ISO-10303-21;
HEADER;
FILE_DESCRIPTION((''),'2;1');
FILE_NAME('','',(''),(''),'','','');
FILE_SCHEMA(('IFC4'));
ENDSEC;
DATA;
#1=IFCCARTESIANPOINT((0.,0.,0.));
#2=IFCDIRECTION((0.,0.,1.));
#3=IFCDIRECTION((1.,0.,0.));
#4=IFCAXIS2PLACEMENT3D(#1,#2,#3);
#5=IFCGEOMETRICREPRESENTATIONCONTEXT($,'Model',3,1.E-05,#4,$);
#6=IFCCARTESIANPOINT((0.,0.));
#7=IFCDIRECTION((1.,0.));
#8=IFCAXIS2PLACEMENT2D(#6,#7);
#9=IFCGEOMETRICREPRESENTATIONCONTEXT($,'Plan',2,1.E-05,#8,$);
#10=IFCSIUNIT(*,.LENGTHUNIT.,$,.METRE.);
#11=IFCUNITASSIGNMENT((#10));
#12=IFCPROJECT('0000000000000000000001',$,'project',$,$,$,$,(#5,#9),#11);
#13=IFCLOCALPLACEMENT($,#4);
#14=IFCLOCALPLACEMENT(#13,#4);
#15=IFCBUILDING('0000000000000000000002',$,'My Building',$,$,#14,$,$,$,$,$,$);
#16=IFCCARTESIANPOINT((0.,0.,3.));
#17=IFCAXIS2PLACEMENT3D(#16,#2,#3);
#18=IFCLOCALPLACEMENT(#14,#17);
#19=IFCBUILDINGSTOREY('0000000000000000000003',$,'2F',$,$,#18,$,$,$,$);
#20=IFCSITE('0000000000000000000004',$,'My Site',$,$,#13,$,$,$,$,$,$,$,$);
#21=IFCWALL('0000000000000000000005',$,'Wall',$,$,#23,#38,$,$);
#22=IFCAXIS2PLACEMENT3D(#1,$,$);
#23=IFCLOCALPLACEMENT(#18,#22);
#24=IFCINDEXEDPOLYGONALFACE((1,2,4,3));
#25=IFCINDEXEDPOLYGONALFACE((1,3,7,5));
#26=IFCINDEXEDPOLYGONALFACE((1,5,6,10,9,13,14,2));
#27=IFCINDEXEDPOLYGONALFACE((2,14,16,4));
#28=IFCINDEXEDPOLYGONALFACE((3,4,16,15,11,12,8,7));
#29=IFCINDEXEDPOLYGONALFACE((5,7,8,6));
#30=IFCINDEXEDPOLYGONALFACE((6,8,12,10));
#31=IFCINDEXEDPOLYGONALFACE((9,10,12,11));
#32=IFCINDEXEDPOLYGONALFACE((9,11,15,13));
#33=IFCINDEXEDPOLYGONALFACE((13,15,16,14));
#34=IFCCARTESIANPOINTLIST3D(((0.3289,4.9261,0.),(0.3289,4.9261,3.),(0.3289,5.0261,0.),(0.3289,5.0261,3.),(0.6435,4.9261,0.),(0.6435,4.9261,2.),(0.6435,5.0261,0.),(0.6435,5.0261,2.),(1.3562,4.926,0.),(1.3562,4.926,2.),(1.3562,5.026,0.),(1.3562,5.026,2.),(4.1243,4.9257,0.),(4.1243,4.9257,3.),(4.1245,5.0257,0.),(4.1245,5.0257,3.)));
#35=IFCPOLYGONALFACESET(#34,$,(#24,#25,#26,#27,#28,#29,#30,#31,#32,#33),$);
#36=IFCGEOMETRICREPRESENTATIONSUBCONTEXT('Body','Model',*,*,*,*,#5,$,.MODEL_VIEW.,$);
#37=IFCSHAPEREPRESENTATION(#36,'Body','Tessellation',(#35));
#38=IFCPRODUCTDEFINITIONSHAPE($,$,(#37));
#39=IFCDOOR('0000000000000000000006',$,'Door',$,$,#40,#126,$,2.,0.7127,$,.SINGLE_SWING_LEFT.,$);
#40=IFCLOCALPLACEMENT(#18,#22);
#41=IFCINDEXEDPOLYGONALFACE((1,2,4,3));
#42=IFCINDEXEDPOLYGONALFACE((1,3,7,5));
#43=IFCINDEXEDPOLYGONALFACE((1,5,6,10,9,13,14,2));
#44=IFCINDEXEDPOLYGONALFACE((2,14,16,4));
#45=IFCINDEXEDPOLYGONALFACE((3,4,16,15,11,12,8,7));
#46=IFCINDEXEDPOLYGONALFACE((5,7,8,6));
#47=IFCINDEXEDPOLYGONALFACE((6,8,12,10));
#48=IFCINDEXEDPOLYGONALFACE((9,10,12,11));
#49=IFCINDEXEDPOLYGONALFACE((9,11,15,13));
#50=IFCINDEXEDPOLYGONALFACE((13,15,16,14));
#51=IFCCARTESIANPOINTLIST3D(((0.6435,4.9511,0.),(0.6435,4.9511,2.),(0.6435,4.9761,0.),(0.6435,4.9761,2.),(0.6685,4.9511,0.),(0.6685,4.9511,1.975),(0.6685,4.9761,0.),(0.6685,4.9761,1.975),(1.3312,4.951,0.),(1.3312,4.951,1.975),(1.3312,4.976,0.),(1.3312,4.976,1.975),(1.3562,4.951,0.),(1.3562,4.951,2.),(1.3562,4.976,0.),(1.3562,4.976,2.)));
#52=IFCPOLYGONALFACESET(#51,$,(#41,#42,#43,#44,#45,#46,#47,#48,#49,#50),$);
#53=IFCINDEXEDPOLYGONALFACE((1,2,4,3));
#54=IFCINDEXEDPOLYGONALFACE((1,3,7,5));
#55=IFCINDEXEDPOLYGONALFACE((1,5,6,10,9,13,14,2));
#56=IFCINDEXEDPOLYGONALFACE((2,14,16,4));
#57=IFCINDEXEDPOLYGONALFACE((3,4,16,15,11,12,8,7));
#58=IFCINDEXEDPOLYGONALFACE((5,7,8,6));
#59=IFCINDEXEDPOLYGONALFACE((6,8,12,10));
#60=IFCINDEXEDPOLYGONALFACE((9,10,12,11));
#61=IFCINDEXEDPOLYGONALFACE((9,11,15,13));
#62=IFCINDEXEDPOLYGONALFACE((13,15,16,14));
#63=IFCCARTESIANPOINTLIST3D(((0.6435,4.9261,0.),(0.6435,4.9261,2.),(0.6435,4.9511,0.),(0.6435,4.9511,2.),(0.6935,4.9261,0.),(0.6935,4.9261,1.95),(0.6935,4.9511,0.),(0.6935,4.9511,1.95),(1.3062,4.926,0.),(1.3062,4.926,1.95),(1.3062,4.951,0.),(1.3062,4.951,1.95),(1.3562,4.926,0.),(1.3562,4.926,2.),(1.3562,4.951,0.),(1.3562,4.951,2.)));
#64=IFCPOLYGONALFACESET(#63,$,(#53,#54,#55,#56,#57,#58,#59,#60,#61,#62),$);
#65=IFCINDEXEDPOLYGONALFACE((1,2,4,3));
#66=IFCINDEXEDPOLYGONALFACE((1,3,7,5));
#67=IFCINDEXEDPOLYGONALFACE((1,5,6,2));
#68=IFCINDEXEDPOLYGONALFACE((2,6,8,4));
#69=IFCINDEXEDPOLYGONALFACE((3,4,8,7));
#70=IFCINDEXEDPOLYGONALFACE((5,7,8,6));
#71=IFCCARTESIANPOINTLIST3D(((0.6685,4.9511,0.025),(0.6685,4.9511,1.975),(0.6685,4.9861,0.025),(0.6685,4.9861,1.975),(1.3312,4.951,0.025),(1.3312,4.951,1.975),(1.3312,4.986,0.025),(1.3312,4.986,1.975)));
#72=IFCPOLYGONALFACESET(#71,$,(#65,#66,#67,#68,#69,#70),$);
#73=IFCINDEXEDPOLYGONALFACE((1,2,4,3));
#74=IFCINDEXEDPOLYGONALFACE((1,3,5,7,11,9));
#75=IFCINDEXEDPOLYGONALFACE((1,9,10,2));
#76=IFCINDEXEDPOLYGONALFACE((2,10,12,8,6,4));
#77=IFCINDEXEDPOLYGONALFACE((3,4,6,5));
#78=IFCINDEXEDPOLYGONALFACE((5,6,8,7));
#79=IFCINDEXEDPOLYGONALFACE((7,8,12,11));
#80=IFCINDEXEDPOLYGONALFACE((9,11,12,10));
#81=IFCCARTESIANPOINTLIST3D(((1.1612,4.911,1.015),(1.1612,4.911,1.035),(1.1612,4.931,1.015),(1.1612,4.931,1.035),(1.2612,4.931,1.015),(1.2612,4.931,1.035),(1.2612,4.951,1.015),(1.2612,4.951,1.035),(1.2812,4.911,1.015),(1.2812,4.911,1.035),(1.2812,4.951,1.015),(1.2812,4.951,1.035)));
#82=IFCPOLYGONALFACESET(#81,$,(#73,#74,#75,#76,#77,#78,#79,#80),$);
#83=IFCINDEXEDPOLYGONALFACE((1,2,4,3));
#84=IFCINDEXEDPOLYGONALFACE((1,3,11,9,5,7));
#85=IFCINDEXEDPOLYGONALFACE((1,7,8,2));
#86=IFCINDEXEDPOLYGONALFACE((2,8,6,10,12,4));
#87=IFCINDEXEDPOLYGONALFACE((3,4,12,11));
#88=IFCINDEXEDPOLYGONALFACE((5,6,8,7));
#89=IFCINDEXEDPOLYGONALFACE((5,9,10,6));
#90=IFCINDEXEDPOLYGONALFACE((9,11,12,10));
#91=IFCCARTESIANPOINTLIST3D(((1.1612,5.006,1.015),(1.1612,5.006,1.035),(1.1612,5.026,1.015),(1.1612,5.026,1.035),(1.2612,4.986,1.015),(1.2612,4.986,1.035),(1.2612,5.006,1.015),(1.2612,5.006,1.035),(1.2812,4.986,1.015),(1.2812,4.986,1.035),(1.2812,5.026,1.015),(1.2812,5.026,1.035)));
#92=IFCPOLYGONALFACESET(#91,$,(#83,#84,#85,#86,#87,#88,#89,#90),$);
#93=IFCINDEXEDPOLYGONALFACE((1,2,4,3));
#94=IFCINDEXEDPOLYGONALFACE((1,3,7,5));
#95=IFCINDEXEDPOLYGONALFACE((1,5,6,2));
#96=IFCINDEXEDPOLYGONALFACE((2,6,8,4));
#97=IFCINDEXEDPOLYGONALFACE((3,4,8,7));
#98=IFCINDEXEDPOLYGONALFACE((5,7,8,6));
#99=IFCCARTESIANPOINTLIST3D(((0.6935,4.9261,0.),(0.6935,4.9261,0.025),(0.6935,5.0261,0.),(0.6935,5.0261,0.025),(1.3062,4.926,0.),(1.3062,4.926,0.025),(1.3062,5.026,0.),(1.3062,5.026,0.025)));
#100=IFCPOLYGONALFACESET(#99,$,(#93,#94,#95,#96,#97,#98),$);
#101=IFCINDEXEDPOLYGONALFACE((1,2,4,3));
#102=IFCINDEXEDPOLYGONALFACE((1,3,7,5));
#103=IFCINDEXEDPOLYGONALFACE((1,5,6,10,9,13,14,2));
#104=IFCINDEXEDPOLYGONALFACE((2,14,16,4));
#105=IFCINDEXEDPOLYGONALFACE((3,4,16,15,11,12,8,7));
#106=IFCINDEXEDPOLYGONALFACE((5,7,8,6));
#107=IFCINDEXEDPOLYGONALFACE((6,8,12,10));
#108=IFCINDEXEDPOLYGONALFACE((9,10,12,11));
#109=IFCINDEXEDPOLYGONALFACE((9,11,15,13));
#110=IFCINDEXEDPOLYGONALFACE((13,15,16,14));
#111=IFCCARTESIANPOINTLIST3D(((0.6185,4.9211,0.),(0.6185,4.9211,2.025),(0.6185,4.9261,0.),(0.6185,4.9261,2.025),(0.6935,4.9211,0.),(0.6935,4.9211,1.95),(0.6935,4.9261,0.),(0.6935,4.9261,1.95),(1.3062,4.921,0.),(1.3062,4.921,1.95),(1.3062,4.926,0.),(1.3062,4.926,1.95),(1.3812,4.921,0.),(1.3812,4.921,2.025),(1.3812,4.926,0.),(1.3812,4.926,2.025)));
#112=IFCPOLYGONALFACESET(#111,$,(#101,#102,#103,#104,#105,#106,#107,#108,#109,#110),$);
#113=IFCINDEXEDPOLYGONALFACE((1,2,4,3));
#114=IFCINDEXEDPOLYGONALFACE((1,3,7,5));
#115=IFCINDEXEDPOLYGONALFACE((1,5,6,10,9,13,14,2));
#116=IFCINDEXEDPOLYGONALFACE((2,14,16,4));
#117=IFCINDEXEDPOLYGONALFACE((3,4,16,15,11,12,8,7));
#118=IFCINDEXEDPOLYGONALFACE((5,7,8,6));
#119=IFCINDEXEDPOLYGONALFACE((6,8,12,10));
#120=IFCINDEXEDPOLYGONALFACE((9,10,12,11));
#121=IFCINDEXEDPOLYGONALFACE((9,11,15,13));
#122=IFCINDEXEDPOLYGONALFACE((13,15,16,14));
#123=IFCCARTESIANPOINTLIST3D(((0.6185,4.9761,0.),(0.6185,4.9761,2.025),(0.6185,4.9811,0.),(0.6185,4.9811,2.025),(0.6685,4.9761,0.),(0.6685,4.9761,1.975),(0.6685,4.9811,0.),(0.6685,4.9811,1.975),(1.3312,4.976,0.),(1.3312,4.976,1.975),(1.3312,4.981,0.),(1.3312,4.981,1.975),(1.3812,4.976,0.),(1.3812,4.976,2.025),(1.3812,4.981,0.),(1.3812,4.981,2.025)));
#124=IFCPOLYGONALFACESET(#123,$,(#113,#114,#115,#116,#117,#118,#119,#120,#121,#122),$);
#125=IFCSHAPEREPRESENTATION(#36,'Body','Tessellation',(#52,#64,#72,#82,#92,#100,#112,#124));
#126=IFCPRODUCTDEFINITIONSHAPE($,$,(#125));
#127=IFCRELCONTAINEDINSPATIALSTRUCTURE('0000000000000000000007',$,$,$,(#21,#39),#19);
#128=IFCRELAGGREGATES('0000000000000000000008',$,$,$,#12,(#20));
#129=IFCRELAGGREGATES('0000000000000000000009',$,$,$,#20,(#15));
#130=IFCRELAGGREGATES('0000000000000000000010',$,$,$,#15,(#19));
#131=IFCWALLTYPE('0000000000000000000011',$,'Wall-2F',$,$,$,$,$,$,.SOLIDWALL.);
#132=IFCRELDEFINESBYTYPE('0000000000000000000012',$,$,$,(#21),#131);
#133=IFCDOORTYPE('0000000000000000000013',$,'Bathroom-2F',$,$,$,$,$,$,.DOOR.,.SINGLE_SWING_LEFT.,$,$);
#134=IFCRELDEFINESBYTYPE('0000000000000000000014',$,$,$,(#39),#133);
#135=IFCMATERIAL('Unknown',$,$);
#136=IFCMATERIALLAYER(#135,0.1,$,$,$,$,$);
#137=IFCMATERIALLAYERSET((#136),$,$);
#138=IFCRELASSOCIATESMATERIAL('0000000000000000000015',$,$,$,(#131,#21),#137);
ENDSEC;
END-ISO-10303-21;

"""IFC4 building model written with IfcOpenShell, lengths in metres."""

from ifc_helpers import new_model, entity, si_unit, frame, origin_with_axes, origin_2d_with_axis, place, context, subcontext, project, spatial, line, indexed_curve, outline, extrude, shape, source, transform, mapped, material, layer, layer_set, layer_usage, type_object, type_shapes, element, fill, save


model = new_model("IFC4")

# Units and contexts
model_context = context("Model", 3, precision=1e-05, world=origin_with_axes())
plan_context = context("Plan", 2, precision=1e-05, world=origin_2d_with_axis())
body_context_1 = subcontext(model_context, "Body", "Model", "MODEL_VIEW")
body_context_2 = subcontext(plan_context, "Body", "Plan", "PLAN_VIEW")
ifc_project = project(units=[si_unit("LENGTHUNIT", "METRE")], contexts=[model_context, plan_context])

# Site, building, storey
site_placement = place(None, origin_with_axes())
site = spatial("IfcSite", under=ifc_project, at=site_placement, Name="My Site")
building_placement = place(site_placement, origin_with_axes())
building = spatial("IfcBuilding", under=site, at=building_placement, Name="My Building")
storey_placement = place(building_placement, frame((0.0, 0.0, 3.0), z_axis=(0.0, 0.0, 1.0), x_axis=(1.0, 0.0, 0.0)))
storey = spatial("IfcBuildingStorey", under=building, at=storey_placement, Name="2F")

# Shared definitions
ifc_material = material(Name="Unknown")

# Shared definitions
ifc_layer_1 = layer(ifc_material, 0.1)
ifc_layer_set_1 = layer_set([ifc_layer_1])
wall_type = type_object("IfcWallType", Name="Wall-2F", PredefinedType="SOLIDWALL", material=ifc_layer_set_1)

# Wall, opening, door
ifc_layer_usage_1 = layer_usage(ifc_layer_set_1, "AXIS2", "POSITIVE", 0.0)
wall_1_placement = place(storey_placement, frame((0.3289, 4.9261, 0.0), z_axis=(0.0, 0.0, 1.0), x_axis=(1.0, -0.000101, 0.0)))
wall_1 = element("IfcWall", 1, at=wall_1_placement, inside=storey, type_object=wall_type, material=ifc_layer_usage_1, Name="Wall", context=body_context_1, shape_type="SweptSolid", body=[
    extrude(outline(indexed_curve([(0.0, 0.0), (0.0, 0.1), (3.7955, 0.1), (3.7954, 0.0)], segments=[line(1, 2, 3, 4, 1)])), origin_with_axes(), (0.0, 0.0, 1.0), 3.0),
])
shared_shape_1 = source(origin_with_axes(), body_context_1, "Body", "SweptSolid", [
    extrude(outline(indexed_curve([(0.0, 0.0), (0.7127, 0.0), (0.7127, 2.0), (0.0, 2.0)], segments=[line(1, 2, 3, 4, 1)])), frame((0.0, -0.6, 0.0), z_axis=(0.0, -1.0, 0.0), x_axis=(1.0, 0.0, 0.0)), (0.0, 0.0, -1.0), 1.2),
])
opening_1_placement = place(wall_1_placement, frame((0.3146, 0.0, 0.0), z_axis=(0.0, 0.0, 1.0), x_axis=(1.0, 0.0, 0.0)))
opening_1 = element("IfcOpeningElement", 2, at=opening_1_placement, cuts=wall_1, PredefinedType="OPENING", context=body_context_1, shape_type="MappedRepresentation", body=[
    mapped(shared_shape_1, transform((0.0, 0.0, 0.0), x_axis=(1.0, 0.0, 0.0), y_axis=(0.0, 1.0, 0.0), z_axis=(0.0, 0.0, 1.0), scale=1.0)),
])
door_type_1 = type_object("IfcDoorType", Name="Bathroom-2F", OperationType="SINGLE_SWING_LEFT", PredefinedType="DOOR")
shared_shape_2 = source(origin_with_axes(), body_context_1, "Body", "SweptSolid", [
    extrude(outline(indexed_curve([(0.0, 0.0), (0.0, 2.0), (0.7127, 2.0), (0.7127, 0.0), (0.6877, 0.0), (0.6877, 1.975), (0.025, 1.975), (0.025, 0.0)], segments=[line(1, 2, 3, 4, 5, 6, 7, 8, 1)])), frame((0.0, 0.025, 0.0), z_axis=(0.0, -1.0, 0.0), x_axis=(1.0, 0.0, 0.0)), (0.0, 0.0, -1.0), 0.025),
    extrude(outline(indexed_curve([(0.0, 0.0), (0.0, 2.0), (0.7127, 2.0), (0.7127, 0.0), (0.6627, 0.0), (0.6627, 1.95), (0.05, 1.95), (0.05, 0.0)], segments=[line(1, 2, 3, 4, 5, 6, 7, 8, 1)])), frame((0.0, 0.0, 0.0), z_axis=(0.0, -1.0, 0.0), x_axis=(1.0, 0.0, 0.0)), (0.0, 0.0, -1.0), 0.025),
    extrude(outline(indexed_curve([(0.0, 0.0), (0.6627, 0.0), (0.6627, 0.035), (0.0, 0.035)], segments=[line(1, 2, 3, 4, 1)])), frame((0.025, 0.025, 0.025), z_axis=(0.0, 0.0, 1.0), x_axis=(1.0, 0.0, 0.0)), (0.0, 0.0, 1.0), 1.95),
    extrude(outline(indexed_curve([(0.0, 0.0), (0.0, -0.04), (-0.12, -0.04), (-0.12, -0.02), (-0.02, -0.02), (-0.02, 0.0)], segments=[line(1, 2, 3, 4, 5, 6, 1)])), frame((0.6377, 0.025, 1.015), z_axis=(0.0, 0.0, 1.0), x_axis=(1.0, 0.0, 0.0)), (0.0, 0.0, 1.0), 0.02),
    extrude(outline(indexed_curve([(0.0, 0.0), (0.0, 0.04), (-0.12, 0.04), (-0.12, 0.02), (-0.02, 0.02), (-0.02, 0.0)], segments=[line(1, 2, 3, 4, 5, 6, 1)])), frame((0.6377, 0.06, 1.015), z_axis=(0.0, 0.0, 1.0), x_axis=(1.0, 0.0, 0.0)), (0.0, 0.0, 1.0), 0.02),
    extrude(outline(indexed_curve([(0.0, 0.0), (0.6127, 0.0), (0.6127, 0.1), (0.0, 0.1)], segments=[line(1, 2, 3, 4, 1)])), frame((0.05, 0.0, 0.0), z_axis=(0.0, 0.0, 1.0), x_axis=(1.0, 0.0, 0.0)), (0.0, 0.0, 1.0), 0.025),
    extrude(outline(indexed_curve([(0.0, 0.0), (0.0, 2.025), (0.7627, 2.025), (0.7627, 0.0), (0.6877, 0.0), (0.6877, 1.95), (0.075, 1.95), (0.075, 0.0)], segments=[line(1, 2, 3, 4, 5, 6, 7, 8, 1)])), frame((-0.025, -0.005, 0.0), z_axis=(0.0, -1.0, 0.0), x_axis=(1.0, 0.0, 0.0)), (0.0, 0.0, -1.0), 0.005),
    extrude(outline(indexed_curve([(0.0, 0.0), (0.0, 2.025), (0.7627, 2.025), (0.7627, 0.0), (0.7127, 0.0), (0.7127, 1.975), (0.05, 1.975), (0.05, 0.0)], segments=[line(1, 2, 3, 4, 5, 6, 7, 8, 1)])), frame((-0.025, 0.05, 0.0), z_axis=(0.0, -1.0, 0.0), x_axis=(1.0, 0.0, 0.0)), (0.0, 0.0, -1.0), 0.005),
])
shared_shape_3 = source(origin_with_axes(), body_context_2, "Body", "Curve2D", [
    entity("IfcIndexedPolyCurve", entity("IfcCartesianPointList2D", [[0.0, 0.0], [0.0, 0.05], [0.025, 0.05], [0.025, 0.025], [0.05, 0.025], [0.05, 0.0]]), [entity("IfcLineIndex", [1, 2, 3, 4, 5, 6, 1])]),
    entity("IfcIndexedPolyCurve", entity("IfcCartesianPointList2D", [[0.7127, 0.0], [0.7127, 0.05], [0.6877, 0.05], [0.6877, 0.025], [0.6627, 0.025], [0.6627, 0.0]]), [entity("IfcLineIndex", [1, 2, 3, 4, 5, 6, 1])]),
    entity("IfcTrimmedCurve", entity("IfcEllipse", entity("IfcAxis2Placement2D", entity("IfcCartesianPoint", [0.06, 0.05]), entity("IfcDirection", [1.0, 0.0])), 0.6277, 0.6627), [entity("IfcCartesianPoint", [0.6877, 0.05])], [entity("IfcCartesianPoint", [0.06, 0.7127])], True, "CARTESIAN"),
    entity("IfcIndexedPolyCurve", entity("IfcCartesianPointList2D", [[0.025, 0.05], [0.06, 0.05], [0.06, 0.7127], [0.025, 0.7127]]), [entity("IfcLineIndex", [1, 2, 3, 4, 1])]),
])
type_shapes(door_type_1, [shared_shape_2, shared_shape_3])
door_1_placement = place(opening_1_placement, frame((0.0, 0.0, 0.0), z_axis=(0.0, 0.0, 1.0), x_axis=(1.0, 0.0, 0.0)))
door_1 = element("IfcDoor", 3, at=door_1_placement, inside=storey, type_object=door_type_1, Name="Door", OperationType="SINGLE_SWING_LEFT", OverallHeight=2.0, OverallWidth=0.7127, shapes=[
    shape(body_context_1, "Body", "MappedRepresentation", [mapped(shared_shape_2, transform((0.0, 0.0, 0.0), x_axis=(1.0, 0.0, 0.0), y_axis=(0.0, 1.0, 0.0), z_axis=(0.0, 0.0, 1.0), scale=1.0))]),
    shape(body_context_2, "Body", "MappedRepresentation", [mapped(shared_shape_3, transform((0.0, 0.0, 0.0), x_axis=(1.0, 0.0, 0.0), y_axis=(0.0, 1.0, 0.0), z_axis=(0.0, 0.0, 1.0), scale=1.0))]),
])
fill(opening_1, door_1)

save(model, "model.ifc")
